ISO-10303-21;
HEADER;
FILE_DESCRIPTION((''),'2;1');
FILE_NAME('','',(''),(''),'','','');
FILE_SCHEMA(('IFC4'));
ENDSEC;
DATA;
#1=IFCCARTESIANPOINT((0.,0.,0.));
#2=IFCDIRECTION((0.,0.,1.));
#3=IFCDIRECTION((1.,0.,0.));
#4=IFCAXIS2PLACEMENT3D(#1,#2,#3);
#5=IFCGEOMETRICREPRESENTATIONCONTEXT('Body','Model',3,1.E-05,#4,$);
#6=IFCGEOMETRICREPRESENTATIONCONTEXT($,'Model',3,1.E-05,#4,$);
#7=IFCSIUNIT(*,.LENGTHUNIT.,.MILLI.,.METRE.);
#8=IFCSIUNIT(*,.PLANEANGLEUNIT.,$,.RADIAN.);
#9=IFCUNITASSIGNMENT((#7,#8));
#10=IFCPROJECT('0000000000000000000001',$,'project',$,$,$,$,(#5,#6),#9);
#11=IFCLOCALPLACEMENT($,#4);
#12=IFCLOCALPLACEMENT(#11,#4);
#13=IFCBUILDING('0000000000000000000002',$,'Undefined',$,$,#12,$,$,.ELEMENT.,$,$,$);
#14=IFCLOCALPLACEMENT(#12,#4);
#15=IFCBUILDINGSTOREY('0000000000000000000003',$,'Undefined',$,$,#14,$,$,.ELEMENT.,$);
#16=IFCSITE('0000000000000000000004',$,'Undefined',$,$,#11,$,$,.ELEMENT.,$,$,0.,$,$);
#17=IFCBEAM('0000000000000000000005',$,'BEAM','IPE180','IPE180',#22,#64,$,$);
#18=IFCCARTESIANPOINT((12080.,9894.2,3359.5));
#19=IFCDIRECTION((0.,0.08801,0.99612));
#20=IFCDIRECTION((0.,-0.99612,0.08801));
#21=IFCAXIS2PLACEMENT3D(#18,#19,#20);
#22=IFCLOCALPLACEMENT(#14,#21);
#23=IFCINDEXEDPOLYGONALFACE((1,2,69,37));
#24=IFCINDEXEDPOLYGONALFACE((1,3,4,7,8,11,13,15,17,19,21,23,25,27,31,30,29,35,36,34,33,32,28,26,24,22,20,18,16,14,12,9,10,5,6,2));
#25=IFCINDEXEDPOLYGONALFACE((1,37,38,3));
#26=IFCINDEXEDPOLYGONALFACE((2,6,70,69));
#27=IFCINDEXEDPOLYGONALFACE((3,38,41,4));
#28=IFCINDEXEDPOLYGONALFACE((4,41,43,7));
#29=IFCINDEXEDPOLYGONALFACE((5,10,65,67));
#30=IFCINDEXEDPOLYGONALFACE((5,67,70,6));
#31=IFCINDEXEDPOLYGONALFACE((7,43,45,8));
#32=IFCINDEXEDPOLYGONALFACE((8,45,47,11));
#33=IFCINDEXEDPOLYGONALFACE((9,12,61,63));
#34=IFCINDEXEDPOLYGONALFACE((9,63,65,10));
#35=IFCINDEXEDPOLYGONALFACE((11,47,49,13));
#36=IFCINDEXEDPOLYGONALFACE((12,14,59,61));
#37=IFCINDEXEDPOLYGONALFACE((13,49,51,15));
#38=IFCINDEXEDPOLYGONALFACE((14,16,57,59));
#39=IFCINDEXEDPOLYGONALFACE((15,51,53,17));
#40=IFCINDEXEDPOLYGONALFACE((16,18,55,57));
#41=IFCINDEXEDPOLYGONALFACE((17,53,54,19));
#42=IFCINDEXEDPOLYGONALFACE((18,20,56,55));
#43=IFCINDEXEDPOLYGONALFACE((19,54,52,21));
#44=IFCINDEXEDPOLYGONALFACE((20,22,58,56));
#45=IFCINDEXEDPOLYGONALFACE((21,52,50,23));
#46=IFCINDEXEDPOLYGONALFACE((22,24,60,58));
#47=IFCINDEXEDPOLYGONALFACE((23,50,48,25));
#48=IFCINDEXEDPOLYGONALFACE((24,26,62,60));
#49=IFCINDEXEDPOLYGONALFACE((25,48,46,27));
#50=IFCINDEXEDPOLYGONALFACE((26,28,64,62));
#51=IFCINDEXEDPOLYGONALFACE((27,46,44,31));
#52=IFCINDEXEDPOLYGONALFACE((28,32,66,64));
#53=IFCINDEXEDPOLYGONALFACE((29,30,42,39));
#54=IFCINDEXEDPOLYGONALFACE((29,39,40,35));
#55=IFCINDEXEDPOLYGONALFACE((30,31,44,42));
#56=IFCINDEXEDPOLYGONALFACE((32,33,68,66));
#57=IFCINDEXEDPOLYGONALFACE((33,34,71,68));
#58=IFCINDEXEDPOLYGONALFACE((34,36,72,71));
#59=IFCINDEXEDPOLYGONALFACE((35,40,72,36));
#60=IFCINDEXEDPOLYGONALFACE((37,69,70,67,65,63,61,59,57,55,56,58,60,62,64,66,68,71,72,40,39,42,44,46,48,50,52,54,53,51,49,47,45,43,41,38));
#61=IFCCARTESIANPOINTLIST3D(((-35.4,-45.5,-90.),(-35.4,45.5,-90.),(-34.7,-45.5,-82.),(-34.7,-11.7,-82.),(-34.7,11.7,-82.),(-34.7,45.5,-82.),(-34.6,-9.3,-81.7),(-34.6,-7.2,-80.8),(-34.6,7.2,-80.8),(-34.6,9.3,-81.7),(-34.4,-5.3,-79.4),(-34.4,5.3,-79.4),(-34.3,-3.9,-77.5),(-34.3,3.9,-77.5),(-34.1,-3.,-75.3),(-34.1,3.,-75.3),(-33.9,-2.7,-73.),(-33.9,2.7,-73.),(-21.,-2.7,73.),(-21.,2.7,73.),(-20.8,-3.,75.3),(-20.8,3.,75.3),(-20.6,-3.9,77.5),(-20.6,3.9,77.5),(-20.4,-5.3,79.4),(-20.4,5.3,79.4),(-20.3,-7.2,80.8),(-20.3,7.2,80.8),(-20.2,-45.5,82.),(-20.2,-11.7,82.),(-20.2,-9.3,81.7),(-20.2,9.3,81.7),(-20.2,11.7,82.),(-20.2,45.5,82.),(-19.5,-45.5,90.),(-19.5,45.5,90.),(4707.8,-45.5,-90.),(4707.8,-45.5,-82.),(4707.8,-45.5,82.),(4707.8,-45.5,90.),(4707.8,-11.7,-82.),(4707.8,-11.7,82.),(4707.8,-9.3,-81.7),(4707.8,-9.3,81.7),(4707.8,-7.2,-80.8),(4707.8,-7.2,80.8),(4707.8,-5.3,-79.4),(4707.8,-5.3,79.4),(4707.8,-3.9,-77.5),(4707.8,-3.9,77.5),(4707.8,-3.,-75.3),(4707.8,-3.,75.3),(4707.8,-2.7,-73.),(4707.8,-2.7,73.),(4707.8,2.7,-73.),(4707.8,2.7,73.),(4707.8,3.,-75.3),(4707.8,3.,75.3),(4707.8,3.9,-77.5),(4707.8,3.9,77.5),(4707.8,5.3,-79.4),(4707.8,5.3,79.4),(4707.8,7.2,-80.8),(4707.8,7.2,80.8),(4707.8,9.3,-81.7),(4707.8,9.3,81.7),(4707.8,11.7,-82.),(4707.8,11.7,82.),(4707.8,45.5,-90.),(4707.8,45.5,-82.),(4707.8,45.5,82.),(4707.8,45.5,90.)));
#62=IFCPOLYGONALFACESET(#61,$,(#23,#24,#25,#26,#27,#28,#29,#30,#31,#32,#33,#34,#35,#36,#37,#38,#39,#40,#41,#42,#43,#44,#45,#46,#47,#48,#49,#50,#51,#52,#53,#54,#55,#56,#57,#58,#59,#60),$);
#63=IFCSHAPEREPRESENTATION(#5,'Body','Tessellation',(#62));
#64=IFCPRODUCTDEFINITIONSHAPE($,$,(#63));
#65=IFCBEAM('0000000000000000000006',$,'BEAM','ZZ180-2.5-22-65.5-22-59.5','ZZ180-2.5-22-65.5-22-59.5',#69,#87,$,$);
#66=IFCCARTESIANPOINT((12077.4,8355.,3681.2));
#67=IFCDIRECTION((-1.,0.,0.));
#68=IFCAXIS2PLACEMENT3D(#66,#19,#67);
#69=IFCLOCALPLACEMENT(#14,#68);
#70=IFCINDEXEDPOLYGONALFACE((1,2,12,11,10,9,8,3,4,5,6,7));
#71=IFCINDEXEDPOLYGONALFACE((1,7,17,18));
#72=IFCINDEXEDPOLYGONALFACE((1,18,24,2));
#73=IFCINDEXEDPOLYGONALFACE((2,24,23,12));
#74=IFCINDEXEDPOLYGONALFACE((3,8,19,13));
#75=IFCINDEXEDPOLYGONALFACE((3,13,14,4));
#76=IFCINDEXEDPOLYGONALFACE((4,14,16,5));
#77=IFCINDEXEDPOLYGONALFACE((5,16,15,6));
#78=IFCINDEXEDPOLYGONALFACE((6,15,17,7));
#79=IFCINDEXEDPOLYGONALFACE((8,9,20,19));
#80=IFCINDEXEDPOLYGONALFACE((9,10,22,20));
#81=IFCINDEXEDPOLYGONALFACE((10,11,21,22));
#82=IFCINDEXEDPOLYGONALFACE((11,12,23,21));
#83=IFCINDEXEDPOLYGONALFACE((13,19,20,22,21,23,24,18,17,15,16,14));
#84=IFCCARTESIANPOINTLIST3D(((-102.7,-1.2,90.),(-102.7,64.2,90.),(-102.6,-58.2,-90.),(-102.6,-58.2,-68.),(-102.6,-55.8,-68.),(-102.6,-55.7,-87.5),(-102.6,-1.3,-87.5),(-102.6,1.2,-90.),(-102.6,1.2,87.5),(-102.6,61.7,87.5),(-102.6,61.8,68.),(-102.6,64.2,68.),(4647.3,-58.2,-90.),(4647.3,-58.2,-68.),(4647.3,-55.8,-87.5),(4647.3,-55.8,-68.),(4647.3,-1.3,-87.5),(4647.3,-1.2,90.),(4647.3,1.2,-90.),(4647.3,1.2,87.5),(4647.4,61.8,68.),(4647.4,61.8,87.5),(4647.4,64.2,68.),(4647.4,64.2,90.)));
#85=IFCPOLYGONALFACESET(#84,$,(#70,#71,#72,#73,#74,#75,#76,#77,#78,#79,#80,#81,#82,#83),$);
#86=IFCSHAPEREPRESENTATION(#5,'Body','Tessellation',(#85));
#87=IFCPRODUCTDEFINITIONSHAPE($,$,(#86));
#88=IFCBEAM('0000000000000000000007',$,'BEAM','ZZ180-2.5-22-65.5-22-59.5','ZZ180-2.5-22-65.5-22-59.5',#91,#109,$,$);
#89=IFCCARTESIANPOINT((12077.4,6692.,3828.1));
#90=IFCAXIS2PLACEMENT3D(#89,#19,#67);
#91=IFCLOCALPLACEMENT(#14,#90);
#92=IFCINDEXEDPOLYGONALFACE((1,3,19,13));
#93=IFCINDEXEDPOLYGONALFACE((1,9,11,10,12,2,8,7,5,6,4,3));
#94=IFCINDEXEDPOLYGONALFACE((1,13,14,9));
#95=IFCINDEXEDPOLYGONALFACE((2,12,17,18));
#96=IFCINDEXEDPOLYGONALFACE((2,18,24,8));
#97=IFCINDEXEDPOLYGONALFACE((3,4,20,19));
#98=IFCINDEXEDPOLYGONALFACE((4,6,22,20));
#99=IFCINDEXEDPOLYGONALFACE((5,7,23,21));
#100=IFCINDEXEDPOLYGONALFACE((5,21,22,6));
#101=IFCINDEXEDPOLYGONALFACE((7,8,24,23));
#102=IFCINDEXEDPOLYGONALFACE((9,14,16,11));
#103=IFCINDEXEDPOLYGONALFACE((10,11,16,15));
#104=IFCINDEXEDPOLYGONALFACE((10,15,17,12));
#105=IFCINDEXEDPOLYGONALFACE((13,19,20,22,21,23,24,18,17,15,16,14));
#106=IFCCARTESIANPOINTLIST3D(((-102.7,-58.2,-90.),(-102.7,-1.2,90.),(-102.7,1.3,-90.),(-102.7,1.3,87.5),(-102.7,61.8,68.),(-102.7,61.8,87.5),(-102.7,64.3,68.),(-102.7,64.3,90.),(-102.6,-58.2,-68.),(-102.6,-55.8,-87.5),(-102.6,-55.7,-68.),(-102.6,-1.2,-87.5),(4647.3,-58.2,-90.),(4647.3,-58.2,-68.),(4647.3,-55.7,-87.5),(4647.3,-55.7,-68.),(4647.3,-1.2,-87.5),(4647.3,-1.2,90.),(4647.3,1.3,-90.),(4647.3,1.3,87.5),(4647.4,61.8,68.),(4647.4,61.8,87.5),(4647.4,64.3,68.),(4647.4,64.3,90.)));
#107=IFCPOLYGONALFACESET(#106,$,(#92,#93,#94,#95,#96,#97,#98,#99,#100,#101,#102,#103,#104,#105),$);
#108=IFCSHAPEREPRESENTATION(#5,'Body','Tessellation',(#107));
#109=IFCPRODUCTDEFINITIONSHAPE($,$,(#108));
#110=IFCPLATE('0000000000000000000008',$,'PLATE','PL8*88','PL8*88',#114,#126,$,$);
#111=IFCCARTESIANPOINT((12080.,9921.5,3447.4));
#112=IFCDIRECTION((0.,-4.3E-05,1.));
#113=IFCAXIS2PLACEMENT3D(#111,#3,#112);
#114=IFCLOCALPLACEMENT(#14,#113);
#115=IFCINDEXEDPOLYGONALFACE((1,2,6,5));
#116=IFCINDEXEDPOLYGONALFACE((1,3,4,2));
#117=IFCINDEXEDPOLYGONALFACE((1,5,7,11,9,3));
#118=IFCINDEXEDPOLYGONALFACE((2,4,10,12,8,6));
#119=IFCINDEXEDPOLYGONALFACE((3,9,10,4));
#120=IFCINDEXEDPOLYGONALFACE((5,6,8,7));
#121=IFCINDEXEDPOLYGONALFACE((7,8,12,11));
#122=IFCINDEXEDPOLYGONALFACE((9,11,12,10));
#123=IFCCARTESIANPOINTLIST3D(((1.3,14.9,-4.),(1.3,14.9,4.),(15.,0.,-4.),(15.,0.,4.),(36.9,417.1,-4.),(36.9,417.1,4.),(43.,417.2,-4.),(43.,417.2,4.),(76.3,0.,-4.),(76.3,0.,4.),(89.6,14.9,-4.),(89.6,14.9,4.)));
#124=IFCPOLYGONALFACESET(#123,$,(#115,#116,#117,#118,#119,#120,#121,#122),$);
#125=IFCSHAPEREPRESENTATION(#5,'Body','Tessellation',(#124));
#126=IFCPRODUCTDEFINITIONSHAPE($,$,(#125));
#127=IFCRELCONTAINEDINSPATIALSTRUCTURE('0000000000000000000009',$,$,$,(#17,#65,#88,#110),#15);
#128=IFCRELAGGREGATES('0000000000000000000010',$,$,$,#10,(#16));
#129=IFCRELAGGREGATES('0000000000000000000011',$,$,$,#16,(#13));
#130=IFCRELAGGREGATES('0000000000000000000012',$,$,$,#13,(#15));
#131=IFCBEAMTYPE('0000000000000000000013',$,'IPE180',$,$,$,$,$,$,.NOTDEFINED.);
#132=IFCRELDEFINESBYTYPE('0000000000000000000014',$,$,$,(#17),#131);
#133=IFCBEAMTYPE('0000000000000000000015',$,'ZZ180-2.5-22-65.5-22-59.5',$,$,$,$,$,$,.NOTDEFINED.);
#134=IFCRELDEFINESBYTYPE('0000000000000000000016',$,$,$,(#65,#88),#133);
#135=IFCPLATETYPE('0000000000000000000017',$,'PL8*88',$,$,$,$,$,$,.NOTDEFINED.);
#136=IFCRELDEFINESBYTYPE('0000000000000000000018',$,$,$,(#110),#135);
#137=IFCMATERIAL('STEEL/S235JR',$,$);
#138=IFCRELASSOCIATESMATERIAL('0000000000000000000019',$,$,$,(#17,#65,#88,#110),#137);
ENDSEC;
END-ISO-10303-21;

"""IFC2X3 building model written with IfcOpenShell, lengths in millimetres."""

from ifc_helpers import new_model, si_unit, frame, origin_with_axes, origin_2d_with_axis, place, context, project, spatial, polyline, i_section, outline, extrude, clip, halfspace, material, type_object, element, save


model = new_model("IFC2X3")

# Units and contexts
model_context_1 = context("Model", 3, precision=1e-05, world=origin_with_axes(), identifier="Body")
model_context_2 = context("Model", 3, precision=1e-05, world=origin_with_axes())
ifc_project = project(units=[si_unit("LENGTHUNIT", "METRE", prefix="MILLI"), si_unit("PLANEANGLEUNIT", "RADIAN")], contexts=[model_context_1, model_context_2])

# Site, building, storey
site_placement = place(None, origin_with_axes())
site = spatial("IfcSite", under=ifc_project, at=site_placement, Name="Undefined", CompositionType="ELEMENT", RefElevation=0.0)
building_placement = place(site_placement, origin_with_axes())
building = spatial("IfcBuilding", under=site, at=building_placement, Name="Undefined", CompositionType="ELEMENT")
storey_placement = place(building_placement, origin_with_axes())
storey = spatial("IfcBuildingStorey", under=building, at=storey_placement, Name="Undefined", CompositionType="ELEMENT")

# Shared definitions
ifc_material = material(Name="STEEL/S235JR")

# Beams
beam_type_1 = type_object("IfcBeamType", Name="IPE180", PredefinedType="NOTDEFINED")
beam_1_placement = place(storey_placement, frame((12080.0, 9894.2, 3359.5), z_axis=(0.0, 0.08801, 0.99612), x_axis=(0.0, -0.99612, 0.08801)))
element("IfcBeam", 1, at=beam_1_placement, inside=storey, type_object=beam_type_1, material=ifc_material, Name="BEAM", Description="IPE180", ObjectType="IPE180", context=model_context_1, shape_type="Clipping", body=[
    clip(clip(extrude(i_section(OverallWidth=91.0, OverallDepth=180.0, WebThickness=5.3, FlangeThickness=8.0, FilletRadius=9.0, at=origin_2d_with_axis()), frame((4707.8, 0.0, 0.0), z_axis=(-1.0, 0.0, 0.0), x_axis=(0.0, -1.0, 0.0)), (0.0, 0.0, 1.0), 4759.2), halfspace(frame((-35.4, 0.0, -90.0), z_axis=(0.99612, 0.0, -0.08801), x_axis=(0.0, -1.0, 0.0)), True)), halfspace(frame((4707.8, 0.0, 95.5), z_axis=(1.0, 0.0, 0.0), x_axis=(0.0, 1.0, 0.0)), False)),
])
beam_type_2 = type_object("IfcBeamType", Name="ZZ180-2.5-22-65.5-22-59.5", PredefinedType="NOTDEFINED")
for number, where, z_axis, x_axis, name in (
    (2, (12077.4, 8355.0, 3681.2), (0.0, 0.08801, 0.99612), (-1.0, 0.0, 0.0), "BEAM"),
    (3, (12077.4, 6692.0, 3828.1), (0.0, 0.08801, 0.99612), (-1.0, 0.0, 0.0), "BEAM"),
):
    element("IfcBeam", number, at=place(storey_placement, frame(where, z_axis=z_axis, x_axis=x_axis)), inside=storey, type_object=beam_type_2, material=ifc_material, Name=name, Description="ZZ180-2.5-22-65.5-22-59.5", ObjectType="ZZ180-2.5-22-65.5-22-59.5", context=model_context_1, shape_type="SweptSolid", body=[
        extrude(outline(polyline([(58.2, -90.0), (58.2, -68.0), (55.8, -68.0), (55.8, -87.5), (1.2, -87.5), (1.2, 90.0), (-64.2, 90.0), (-64.2, 68.0), (-61.8, 68.0), (-61.8, 87.5), (-1.2, 87.5), (-1.2, -90.0), (58.2, -90.0)])), frame((4647.4, 0.0, 0.0), z_axis=(-1.0, 0.0, 0.0), x_axis=(0.0, -1.0, 0.0)), (0.0, 0.0, 1.0), 4750.0),
    ])

# Plate
plate_type_1 = type_object("IfcPlateType", Name="PL8*88", PredefinedType="NOTDEFINED")
plate_1_placement = place(storey_placement, frame((12080.0, 9921.5, 3447.4), z_axis=(1.0, 0.0, 0.0), x_axis=(0.0, -0.000043, 1.0)))
element("IfcPlate", 4, at=plate_1_placement, inside=storey, type_object=plate_type_1, material=ifc_material, Name="PLATE", Description="PL8*88", ObjectType="PL8*88", context=model_context_1, shape_type="SweptSolid", body=[
    extrude(outline(polyline([(1.3, 14.9), (15.0, 0.0), (76.3, 0.0), (89.6, 14.9), (43.0, 417.2), (36.9, 417.1), (1.3, 14.9)])), frame((0.0, 0.0, -4.0), z_axis=(0.0, 0.0, 1.0), x_axis=(1.0, 0.0, 0.0)), (0.0, 0.0, 1.0), 8.0),
])

save(model, "model.ifc")
